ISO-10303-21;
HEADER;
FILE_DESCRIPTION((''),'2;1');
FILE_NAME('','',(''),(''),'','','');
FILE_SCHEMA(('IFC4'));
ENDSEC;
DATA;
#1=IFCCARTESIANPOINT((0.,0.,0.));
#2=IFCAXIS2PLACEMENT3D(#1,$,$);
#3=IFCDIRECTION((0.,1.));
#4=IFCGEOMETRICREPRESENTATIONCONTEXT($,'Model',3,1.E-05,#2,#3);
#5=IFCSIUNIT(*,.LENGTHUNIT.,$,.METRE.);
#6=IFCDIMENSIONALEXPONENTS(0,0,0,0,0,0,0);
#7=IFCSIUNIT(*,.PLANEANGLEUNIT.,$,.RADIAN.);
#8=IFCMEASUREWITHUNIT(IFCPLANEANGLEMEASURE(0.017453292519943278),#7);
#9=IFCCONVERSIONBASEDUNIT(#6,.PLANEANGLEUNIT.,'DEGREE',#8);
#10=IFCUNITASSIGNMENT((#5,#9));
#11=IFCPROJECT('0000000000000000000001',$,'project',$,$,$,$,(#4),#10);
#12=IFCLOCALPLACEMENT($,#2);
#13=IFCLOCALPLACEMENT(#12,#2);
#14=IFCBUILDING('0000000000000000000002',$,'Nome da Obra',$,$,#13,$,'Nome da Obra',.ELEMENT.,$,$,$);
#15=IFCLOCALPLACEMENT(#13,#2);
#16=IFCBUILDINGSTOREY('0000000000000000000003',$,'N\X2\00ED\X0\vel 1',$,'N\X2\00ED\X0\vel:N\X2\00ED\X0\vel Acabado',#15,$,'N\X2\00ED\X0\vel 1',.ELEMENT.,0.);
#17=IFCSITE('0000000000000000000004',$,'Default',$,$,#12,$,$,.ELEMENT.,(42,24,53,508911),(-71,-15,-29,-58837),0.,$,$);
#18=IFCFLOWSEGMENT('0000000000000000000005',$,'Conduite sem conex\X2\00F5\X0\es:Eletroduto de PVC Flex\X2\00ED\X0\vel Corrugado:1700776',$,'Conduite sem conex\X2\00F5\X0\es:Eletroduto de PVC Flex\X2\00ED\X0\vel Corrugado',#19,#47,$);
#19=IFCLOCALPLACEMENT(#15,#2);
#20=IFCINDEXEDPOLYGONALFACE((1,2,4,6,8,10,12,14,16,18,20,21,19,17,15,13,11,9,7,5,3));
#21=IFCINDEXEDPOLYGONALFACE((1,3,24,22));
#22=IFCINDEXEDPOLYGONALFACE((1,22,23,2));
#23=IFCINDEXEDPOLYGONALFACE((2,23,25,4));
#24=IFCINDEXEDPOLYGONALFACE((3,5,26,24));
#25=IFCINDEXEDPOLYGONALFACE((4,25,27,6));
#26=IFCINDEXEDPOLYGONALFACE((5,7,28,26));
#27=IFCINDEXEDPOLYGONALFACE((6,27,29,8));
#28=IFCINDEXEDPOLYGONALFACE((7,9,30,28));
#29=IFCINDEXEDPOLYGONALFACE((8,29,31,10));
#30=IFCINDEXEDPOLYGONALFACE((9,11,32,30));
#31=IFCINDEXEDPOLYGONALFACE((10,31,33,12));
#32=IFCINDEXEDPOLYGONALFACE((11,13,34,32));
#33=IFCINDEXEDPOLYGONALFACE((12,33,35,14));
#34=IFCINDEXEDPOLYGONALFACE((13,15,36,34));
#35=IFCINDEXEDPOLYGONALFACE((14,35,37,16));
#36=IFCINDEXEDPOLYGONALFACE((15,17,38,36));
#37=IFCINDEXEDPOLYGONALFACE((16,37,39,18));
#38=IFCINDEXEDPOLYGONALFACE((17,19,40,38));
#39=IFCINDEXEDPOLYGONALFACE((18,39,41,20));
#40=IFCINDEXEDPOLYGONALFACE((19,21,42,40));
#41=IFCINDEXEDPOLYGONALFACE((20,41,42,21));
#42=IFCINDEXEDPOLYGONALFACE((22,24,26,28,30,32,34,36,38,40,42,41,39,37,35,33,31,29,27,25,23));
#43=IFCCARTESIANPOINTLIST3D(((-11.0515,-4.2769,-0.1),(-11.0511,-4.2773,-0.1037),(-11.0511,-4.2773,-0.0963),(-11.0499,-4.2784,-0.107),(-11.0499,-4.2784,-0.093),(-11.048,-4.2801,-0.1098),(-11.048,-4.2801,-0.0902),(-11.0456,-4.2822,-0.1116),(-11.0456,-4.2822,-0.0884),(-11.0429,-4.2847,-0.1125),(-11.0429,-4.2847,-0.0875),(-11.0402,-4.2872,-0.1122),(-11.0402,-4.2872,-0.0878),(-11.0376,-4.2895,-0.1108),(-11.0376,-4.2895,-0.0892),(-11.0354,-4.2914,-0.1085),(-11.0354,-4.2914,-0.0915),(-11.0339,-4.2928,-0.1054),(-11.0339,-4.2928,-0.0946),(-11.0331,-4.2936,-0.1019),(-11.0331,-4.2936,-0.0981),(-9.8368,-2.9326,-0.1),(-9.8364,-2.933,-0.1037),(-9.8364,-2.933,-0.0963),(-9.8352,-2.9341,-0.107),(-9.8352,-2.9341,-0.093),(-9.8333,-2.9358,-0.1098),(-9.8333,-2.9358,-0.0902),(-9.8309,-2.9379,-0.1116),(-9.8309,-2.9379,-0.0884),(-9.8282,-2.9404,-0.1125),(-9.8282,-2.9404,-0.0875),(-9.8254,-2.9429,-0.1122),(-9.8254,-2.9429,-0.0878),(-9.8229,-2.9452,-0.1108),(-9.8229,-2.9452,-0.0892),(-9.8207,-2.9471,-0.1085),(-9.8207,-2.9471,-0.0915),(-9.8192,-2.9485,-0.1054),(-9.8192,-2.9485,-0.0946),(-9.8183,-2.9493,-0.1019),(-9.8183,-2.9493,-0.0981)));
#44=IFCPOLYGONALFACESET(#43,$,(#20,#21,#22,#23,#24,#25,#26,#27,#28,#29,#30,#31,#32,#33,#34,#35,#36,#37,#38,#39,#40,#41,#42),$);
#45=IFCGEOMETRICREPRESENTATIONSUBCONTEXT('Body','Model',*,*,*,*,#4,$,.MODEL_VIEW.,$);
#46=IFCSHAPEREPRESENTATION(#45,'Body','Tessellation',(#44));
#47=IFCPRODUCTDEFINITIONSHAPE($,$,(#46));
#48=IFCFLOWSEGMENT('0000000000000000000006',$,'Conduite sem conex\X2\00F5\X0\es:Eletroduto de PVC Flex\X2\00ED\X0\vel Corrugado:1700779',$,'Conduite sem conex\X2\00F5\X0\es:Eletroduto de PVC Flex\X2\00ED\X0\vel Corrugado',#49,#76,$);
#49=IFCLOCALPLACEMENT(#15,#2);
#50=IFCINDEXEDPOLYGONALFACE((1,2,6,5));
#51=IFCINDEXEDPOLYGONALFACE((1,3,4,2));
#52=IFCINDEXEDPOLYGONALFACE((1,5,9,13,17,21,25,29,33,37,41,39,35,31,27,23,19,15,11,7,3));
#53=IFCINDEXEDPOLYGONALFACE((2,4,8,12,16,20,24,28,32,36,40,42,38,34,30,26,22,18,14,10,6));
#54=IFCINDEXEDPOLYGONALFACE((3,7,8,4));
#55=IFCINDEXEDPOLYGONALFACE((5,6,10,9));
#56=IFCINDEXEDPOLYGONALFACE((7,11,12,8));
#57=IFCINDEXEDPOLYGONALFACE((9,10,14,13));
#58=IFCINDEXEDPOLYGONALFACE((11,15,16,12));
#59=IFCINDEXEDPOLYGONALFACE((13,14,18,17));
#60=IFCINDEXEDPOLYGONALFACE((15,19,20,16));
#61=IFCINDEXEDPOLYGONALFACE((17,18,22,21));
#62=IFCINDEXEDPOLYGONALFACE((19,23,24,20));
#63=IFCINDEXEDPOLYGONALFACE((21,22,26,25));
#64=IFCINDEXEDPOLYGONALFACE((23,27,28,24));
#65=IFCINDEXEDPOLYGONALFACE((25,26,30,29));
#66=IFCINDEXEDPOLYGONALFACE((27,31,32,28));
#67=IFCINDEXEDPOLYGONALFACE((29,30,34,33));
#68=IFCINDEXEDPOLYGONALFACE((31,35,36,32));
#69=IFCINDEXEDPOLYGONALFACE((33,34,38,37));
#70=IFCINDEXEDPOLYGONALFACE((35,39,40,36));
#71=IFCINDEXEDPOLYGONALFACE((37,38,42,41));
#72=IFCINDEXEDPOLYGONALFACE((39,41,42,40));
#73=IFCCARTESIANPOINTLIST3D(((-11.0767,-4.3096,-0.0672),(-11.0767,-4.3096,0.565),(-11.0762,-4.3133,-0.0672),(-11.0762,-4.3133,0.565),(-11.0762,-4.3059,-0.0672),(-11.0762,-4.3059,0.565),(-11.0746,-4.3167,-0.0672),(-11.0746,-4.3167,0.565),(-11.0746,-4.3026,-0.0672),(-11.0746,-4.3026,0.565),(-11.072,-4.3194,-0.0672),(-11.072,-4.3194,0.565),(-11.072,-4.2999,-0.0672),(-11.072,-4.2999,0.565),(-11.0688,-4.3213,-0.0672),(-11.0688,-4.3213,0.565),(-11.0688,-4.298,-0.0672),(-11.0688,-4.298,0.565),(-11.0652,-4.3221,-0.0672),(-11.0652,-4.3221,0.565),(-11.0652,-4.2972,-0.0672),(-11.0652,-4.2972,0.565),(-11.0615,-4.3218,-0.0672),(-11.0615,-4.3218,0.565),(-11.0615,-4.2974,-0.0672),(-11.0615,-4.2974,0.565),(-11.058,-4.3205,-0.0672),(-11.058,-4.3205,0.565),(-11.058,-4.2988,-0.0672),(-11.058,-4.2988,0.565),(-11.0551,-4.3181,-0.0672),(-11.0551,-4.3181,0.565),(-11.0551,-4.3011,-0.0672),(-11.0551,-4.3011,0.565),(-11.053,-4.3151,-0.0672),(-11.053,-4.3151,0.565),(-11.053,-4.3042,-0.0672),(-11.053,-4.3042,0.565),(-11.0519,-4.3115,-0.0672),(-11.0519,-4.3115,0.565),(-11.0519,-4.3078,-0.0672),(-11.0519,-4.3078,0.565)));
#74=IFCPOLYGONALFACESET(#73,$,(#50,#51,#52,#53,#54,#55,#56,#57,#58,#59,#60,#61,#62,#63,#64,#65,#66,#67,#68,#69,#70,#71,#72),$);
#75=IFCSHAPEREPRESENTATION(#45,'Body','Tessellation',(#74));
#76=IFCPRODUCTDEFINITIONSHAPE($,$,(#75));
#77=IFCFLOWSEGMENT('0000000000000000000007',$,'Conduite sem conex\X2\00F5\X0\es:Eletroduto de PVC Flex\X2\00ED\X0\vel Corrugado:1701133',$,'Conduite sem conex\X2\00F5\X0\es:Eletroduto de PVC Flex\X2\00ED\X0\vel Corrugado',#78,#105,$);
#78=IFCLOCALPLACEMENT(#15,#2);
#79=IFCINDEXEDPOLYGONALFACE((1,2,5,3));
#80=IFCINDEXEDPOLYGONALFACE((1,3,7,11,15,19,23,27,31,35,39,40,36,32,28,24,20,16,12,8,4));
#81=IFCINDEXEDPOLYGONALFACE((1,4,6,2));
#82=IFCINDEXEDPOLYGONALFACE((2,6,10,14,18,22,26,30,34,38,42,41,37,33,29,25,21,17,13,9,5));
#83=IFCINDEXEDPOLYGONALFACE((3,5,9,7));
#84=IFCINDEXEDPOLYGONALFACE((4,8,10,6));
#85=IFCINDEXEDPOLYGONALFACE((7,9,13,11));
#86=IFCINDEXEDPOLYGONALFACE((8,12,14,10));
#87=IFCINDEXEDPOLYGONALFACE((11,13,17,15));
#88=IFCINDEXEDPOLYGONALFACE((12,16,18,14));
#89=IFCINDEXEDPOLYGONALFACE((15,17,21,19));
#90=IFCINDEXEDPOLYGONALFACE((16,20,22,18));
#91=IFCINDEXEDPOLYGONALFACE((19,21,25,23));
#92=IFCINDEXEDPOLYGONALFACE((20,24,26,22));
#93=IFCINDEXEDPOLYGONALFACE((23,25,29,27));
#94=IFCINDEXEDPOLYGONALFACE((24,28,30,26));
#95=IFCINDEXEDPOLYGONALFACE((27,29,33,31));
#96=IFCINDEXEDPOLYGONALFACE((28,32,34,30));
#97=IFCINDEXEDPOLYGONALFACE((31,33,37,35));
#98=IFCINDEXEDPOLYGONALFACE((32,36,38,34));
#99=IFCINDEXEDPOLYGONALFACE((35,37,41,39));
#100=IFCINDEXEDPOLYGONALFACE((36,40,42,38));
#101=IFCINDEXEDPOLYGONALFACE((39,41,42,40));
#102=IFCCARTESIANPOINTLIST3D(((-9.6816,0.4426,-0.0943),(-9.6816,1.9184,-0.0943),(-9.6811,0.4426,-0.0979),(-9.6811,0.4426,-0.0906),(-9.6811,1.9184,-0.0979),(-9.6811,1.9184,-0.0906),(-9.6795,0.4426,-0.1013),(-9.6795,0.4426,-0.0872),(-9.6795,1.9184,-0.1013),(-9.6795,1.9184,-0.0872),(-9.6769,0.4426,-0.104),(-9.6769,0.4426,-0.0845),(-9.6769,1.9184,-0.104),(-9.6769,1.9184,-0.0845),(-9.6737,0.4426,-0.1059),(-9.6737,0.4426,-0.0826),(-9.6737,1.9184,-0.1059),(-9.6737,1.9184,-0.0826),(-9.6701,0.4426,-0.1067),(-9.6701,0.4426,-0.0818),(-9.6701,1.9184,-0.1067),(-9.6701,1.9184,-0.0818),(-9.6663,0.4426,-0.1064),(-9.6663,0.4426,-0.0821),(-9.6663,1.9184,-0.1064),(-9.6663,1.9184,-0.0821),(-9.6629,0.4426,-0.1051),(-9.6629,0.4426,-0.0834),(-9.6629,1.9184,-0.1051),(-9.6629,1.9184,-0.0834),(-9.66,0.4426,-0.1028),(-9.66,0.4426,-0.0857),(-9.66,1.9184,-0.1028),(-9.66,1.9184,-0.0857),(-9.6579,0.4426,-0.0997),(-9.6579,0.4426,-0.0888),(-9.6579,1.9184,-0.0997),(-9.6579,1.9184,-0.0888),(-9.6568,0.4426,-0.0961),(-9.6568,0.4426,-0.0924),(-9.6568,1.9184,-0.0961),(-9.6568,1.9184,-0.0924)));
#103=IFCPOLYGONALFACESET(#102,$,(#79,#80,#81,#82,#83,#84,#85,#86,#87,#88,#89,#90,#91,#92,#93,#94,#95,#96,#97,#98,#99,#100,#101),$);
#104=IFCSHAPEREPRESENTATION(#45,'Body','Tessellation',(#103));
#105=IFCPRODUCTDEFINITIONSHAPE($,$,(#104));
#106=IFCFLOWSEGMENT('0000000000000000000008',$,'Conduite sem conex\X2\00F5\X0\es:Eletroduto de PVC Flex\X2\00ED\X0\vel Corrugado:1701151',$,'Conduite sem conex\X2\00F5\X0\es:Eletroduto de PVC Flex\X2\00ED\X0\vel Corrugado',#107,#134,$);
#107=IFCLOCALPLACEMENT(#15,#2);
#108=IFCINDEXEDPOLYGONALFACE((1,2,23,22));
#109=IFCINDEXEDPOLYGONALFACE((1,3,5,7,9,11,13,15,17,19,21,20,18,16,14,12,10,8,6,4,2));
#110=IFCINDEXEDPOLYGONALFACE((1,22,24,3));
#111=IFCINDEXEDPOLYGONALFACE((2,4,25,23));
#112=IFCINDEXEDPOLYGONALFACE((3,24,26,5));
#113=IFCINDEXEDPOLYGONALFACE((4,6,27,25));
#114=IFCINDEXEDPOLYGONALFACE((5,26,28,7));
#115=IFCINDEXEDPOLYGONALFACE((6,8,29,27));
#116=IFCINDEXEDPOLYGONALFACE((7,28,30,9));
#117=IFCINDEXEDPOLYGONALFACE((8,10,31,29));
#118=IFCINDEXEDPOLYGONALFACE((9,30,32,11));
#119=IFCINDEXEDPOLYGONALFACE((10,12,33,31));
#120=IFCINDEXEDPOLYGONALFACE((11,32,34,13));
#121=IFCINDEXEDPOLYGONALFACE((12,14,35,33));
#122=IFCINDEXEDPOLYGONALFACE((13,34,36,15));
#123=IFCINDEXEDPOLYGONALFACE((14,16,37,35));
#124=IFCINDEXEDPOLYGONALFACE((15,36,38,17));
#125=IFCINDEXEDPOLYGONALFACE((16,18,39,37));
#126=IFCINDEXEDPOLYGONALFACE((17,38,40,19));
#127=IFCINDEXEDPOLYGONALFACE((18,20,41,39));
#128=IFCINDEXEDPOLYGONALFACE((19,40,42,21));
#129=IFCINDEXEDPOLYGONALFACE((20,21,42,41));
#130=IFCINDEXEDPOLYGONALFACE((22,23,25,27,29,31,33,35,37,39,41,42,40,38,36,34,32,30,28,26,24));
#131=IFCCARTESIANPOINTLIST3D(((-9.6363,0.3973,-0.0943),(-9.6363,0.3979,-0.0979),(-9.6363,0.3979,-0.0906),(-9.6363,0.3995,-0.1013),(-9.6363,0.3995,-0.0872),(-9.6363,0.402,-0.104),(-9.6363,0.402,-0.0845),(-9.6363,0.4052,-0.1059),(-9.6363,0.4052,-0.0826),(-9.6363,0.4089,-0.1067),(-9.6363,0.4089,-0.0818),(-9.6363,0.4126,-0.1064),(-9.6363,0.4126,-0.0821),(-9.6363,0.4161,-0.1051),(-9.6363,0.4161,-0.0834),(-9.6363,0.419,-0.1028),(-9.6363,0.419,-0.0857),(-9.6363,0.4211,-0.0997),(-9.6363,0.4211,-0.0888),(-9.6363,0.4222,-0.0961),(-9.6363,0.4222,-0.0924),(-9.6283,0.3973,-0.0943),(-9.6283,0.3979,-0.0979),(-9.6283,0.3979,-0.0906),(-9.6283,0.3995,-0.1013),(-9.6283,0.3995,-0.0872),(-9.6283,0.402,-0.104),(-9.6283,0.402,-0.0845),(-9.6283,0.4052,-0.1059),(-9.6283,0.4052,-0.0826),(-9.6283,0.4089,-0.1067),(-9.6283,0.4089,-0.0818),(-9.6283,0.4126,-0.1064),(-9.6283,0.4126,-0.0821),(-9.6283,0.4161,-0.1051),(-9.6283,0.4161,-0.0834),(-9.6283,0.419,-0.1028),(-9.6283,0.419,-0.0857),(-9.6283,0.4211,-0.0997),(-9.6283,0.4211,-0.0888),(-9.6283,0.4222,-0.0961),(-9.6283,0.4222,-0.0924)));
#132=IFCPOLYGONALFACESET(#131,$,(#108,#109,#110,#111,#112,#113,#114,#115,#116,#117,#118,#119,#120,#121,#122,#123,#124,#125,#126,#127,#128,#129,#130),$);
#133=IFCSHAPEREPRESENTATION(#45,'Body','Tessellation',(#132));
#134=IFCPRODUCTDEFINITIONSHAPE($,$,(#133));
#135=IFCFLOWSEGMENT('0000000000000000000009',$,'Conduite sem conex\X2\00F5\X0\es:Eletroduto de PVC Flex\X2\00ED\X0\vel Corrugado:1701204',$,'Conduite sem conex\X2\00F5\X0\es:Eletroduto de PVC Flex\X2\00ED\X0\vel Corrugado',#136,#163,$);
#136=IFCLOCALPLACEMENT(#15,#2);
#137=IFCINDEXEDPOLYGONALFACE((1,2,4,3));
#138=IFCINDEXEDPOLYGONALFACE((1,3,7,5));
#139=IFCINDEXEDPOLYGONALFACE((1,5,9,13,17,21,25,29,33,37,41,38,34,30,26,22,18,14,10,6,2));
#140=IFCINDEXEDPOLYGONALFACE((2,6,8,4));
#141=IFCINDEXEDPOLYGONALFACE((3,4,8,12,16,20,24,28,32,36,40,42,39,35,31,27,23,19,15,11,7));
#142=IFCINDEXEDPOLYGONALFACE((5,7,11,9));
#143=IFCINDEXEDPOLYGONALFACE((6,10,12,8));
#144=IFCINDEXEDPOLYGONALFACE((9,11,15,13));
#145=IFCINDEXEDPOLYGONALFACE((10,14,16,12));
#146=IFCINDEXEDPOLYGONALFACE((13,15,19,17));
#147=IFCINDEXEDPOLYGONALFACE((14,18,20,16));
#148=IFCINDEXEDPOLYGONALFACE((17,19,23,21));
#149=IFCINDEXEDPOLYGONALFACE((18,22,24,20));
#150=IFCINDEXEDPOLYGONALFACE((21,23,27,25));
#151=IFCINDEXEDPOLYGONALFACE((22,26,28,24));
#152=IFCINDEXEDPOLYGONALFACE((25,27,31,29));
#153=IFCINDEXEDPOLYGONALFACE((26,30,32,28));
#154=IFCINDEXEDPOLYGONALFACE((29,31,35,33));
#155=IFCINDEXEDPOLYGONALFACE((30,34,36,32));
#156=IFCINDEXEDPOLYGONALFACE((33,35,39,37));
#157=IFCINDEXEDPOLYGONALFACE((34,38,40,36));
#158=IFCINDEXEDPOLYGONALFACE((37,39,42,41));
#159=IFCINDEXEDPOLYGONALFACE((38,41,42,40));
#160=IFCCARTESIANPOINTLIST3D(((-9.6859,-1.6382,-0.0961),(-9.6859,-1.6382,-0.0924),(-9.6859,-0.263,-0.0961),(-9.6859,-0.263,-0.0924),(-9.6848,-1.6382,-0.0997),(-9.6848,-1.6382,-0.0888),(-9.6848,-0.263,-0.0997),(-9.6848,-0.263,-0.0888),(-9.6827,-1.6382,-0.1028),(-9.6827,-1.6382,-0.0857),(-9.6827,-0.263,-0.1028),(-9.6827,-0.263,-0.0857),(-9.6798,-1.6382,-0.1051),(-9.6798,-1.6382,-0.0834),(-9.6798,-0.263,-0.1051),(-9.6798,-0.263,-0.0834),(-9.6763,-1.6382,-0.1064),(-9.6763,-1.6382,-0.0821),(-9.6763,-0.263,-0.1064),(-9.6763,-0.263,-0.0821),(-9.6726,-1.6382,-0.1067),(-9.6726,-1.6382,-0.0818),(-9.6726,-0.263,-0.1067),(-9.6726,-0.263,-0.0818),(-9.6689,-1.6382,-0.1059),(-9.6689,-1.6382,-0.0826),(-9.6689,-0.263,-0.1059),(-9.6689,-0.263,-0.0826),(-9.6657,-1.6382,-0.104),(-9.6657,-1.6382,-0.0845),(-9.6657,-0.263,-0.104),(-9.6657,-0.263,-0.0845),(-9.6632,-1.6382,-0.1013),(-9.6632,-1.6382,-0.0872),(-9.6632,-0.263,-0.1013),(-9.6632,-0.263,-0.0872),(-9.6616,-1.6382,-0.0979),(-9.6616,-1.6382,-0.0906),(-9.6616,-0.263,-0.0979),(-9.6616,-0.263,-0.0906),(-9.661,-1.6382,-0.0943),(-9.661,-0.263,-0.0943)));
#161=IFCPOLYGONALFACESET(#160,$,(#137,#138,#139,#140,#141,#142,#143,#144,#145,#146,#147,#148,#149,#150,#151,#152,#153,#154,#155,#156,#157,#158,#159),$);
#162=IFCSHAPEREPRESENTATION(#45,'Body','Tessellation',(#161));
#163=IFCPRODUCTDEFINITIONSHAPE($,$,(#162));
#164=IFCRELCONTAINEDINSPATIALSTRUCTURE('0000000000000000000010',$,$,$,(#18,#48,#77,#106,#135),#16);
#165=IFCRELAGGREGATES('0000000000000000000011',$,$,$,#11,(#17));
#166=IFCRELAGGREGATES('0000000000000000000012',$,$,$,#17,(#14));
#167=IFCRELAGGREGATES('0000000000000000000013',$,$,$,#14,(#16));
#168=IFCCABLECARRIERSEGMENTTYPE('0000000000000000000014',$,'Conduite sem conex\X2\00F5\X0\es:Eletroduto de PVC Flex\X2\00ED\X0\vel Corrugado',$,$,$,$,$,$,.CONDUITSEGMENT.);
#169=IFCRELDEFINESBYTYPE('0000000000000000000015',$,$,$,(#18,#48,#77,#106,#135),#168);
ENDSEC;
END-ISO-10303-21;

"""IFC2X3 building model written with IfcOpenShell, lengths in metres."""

from ifc_helpers import new_model, entity, si_unit, converted_unit, direction, frame, frame_2d, origin, origin_2d_with_axis, place, context, subcontext, project, spatial, circle, extrude, type_object, element, save


model = new_model("IFC2X3")

# Units and contexts
model_context = context("Model", 3, precision=1e-05, world=origin(), true_north=direction((0.0, 1.0)))
body_context = subcontext(model_context, "Body", "Model", "MODEL_VIEW")
ifc_project = project(units=[si_unit("LENGTHUNIT", "METRE"), converted_unit("PLANEANGLEUNIT", "DEGREE", entity("IfcPlaneAngleMeasure", 0.017453292519943278), si_unit("PLANEANGLEUNIT", "RADIAN"), dimensions=[0, 0, 0, 0, 0, 0, 0])], contexts=[model_context])

# Site, building, storey
site_placement = place(None, origin())
site = spatial("IfcSite", under=ifc_project, at=site_placement, Name="Default", CompositionType="ELEMENT", RefLatitude=(42, 24, 53, 508911), RefLongitude=(-71, -15, -29, -58837), RefElevation=0.0)
building_placement = place(site_placement, origin())
building = spatial("IfcBuilding", under=site, at=building_placement, Name="Nome da Obra", LongName="Nome da Obra", CompositionType="ELEMENT")
storey_placement = place(building_placement, origin())
storey = spatial("IfcBuildingStorey", under=building, at=storey_placement, Name="Nível 1", ObjectType="Nível:Nível Acabado", LongName="Nível 1", CompositionType="ELEMENT", Elevation=0.0)

# Flow segments
cable_carrier_segment_type = type_object("IfcCableCarrierSegmentType", Name="Conduite sem conexões:Eletroduto de PVC Flexível Corrugado", PredefinedType="CONDUITSEGMENT")
flow_segment_1_placement = place(storey_placement, origin())
element("IfcFlowSegment", 1, at=flow_segment_1_placement, inside=storey, type_object=cable_carrier_segment_type, Name="Conduite sem conexões:Eletroduto de PVC Flexível Corrugado:1700776", ObjectType="Conduite sem conexões:Eletroduto de PVC Flexível Corrugado", context=body_context, shape_type="SweptSolid", body=[
    extrude(circle(Radius=0.0125, at=frame_2d((0.0, 0.0), x_axis=(1.0, 0.0))), frame((-11.0422, -4.2853, -0.1), z_axis=(0.670448, 0.741956, 0.0), x_axis=(-0.741956, 0.670448, 0.0)), (0.0, 0.0, 1.0), 1.8118),
])
flow_segment_2_placement = place(storey_placement, origin())
element("IfcFlowSegment", 2, at=flow_segment_2_placement, inside=storey, type_object=cable_carrier_segment_type, Name="Conduite sem conexões:Eletroduto de PVC Flexível Corrugado:1700779", ObjectType="Conduite sem conexões:Eletroduto de PVC Flexível Corrugado", context=body_context, shape_type="SweptSolid", body=[
    extrude(circle(Radius=0.0125, at=frame_2d((0.0, 0.0), x_axis=(1.0, 0.0))), frame((-11.0642, -4.3096, -0.0672), z_axis=(0.0, 0.0, 1.0), x_axis=(-1.0, 0.0, 0.0)), (0.0, 0.0, 1.0), 0.6322),
])
flow_segment_3_placement = place(storey_placement, origin())
element("IfcFlowSegment", 3, at=flow_segment_3_placement, inside=storey, type_object=cable_carrier_segment_type, Name="Conduite sem conexões:Eletroduto de PVC Flexível Corrugado:1701133", ObjectType="Conduite sem conexões:Eletroduto de PVC Flexível Corrugado", context=body_context, shape_type="SweptSolid", body=[
    extrude(circle(Radius=0.0125, at=frame_2d((0.0, 0.0), x_axis=(1.0, 0.0))), frame((-9.6691, 0.4426, -0.0943), z_axis=(0.0, 1.0, 0.0), x_axis=(-1.0, 0.0, 0.0)), (0.0, 0.0, 1.0), 1.4758),
])
flow_segment_4_placement = place(storey_placement, origin())
element("IfcFlowSegment", 4, at=flow_segment_4_placement, inside=storey, type_object=cable_carrier_segment_type, Name="Conduite sem conexões:Eletroduto de PVC Flexível Corrugado:1701151", ObjectType="Conduite sem conexões:Eletroduto de PVC Flexível Corrugado", context=body_context, shape_type="SweptSolid", body=[
    extrude(circle(Radius=0.0125, at=frame_2d((0.0, 0.0), x_axis=(1.0, 0.0))), frame((-9.6363, 0.4098, -0.0943), z_axis=(1.0, 0.0, 0.0), x_axis=(0.0, -1.0, 0.0)), (0.0, 0.0, 1.0), 0.008),
])
flow_segment_5_placement = place(storey_placement, origin())
element("IfcFlowSegment", 5, at=flow_segment_5_placement, inside=storey, type_object=cable_carrier_segment_type, Name="Conduite sem conexões:Eletroduto de PVC Flexível Corrugado:1701204", ObjectType="Conduite sem conexões:Eletroduto de PVC Flexível Corrugado", context=body_context, shape_type="SweptSolid", body=[
    extrude(circle(Radius=0.0125, at=origin_2d_with_axis()), frame((-9.6735, -1.6382, -0.0943), z_axis=(0.0, 1.0, 0.0), x_axis=(1.0, 0.0, 0.0)), (0.0, 0.0, 1.0), 1.3752),
])

save(model, "model.ifc")
